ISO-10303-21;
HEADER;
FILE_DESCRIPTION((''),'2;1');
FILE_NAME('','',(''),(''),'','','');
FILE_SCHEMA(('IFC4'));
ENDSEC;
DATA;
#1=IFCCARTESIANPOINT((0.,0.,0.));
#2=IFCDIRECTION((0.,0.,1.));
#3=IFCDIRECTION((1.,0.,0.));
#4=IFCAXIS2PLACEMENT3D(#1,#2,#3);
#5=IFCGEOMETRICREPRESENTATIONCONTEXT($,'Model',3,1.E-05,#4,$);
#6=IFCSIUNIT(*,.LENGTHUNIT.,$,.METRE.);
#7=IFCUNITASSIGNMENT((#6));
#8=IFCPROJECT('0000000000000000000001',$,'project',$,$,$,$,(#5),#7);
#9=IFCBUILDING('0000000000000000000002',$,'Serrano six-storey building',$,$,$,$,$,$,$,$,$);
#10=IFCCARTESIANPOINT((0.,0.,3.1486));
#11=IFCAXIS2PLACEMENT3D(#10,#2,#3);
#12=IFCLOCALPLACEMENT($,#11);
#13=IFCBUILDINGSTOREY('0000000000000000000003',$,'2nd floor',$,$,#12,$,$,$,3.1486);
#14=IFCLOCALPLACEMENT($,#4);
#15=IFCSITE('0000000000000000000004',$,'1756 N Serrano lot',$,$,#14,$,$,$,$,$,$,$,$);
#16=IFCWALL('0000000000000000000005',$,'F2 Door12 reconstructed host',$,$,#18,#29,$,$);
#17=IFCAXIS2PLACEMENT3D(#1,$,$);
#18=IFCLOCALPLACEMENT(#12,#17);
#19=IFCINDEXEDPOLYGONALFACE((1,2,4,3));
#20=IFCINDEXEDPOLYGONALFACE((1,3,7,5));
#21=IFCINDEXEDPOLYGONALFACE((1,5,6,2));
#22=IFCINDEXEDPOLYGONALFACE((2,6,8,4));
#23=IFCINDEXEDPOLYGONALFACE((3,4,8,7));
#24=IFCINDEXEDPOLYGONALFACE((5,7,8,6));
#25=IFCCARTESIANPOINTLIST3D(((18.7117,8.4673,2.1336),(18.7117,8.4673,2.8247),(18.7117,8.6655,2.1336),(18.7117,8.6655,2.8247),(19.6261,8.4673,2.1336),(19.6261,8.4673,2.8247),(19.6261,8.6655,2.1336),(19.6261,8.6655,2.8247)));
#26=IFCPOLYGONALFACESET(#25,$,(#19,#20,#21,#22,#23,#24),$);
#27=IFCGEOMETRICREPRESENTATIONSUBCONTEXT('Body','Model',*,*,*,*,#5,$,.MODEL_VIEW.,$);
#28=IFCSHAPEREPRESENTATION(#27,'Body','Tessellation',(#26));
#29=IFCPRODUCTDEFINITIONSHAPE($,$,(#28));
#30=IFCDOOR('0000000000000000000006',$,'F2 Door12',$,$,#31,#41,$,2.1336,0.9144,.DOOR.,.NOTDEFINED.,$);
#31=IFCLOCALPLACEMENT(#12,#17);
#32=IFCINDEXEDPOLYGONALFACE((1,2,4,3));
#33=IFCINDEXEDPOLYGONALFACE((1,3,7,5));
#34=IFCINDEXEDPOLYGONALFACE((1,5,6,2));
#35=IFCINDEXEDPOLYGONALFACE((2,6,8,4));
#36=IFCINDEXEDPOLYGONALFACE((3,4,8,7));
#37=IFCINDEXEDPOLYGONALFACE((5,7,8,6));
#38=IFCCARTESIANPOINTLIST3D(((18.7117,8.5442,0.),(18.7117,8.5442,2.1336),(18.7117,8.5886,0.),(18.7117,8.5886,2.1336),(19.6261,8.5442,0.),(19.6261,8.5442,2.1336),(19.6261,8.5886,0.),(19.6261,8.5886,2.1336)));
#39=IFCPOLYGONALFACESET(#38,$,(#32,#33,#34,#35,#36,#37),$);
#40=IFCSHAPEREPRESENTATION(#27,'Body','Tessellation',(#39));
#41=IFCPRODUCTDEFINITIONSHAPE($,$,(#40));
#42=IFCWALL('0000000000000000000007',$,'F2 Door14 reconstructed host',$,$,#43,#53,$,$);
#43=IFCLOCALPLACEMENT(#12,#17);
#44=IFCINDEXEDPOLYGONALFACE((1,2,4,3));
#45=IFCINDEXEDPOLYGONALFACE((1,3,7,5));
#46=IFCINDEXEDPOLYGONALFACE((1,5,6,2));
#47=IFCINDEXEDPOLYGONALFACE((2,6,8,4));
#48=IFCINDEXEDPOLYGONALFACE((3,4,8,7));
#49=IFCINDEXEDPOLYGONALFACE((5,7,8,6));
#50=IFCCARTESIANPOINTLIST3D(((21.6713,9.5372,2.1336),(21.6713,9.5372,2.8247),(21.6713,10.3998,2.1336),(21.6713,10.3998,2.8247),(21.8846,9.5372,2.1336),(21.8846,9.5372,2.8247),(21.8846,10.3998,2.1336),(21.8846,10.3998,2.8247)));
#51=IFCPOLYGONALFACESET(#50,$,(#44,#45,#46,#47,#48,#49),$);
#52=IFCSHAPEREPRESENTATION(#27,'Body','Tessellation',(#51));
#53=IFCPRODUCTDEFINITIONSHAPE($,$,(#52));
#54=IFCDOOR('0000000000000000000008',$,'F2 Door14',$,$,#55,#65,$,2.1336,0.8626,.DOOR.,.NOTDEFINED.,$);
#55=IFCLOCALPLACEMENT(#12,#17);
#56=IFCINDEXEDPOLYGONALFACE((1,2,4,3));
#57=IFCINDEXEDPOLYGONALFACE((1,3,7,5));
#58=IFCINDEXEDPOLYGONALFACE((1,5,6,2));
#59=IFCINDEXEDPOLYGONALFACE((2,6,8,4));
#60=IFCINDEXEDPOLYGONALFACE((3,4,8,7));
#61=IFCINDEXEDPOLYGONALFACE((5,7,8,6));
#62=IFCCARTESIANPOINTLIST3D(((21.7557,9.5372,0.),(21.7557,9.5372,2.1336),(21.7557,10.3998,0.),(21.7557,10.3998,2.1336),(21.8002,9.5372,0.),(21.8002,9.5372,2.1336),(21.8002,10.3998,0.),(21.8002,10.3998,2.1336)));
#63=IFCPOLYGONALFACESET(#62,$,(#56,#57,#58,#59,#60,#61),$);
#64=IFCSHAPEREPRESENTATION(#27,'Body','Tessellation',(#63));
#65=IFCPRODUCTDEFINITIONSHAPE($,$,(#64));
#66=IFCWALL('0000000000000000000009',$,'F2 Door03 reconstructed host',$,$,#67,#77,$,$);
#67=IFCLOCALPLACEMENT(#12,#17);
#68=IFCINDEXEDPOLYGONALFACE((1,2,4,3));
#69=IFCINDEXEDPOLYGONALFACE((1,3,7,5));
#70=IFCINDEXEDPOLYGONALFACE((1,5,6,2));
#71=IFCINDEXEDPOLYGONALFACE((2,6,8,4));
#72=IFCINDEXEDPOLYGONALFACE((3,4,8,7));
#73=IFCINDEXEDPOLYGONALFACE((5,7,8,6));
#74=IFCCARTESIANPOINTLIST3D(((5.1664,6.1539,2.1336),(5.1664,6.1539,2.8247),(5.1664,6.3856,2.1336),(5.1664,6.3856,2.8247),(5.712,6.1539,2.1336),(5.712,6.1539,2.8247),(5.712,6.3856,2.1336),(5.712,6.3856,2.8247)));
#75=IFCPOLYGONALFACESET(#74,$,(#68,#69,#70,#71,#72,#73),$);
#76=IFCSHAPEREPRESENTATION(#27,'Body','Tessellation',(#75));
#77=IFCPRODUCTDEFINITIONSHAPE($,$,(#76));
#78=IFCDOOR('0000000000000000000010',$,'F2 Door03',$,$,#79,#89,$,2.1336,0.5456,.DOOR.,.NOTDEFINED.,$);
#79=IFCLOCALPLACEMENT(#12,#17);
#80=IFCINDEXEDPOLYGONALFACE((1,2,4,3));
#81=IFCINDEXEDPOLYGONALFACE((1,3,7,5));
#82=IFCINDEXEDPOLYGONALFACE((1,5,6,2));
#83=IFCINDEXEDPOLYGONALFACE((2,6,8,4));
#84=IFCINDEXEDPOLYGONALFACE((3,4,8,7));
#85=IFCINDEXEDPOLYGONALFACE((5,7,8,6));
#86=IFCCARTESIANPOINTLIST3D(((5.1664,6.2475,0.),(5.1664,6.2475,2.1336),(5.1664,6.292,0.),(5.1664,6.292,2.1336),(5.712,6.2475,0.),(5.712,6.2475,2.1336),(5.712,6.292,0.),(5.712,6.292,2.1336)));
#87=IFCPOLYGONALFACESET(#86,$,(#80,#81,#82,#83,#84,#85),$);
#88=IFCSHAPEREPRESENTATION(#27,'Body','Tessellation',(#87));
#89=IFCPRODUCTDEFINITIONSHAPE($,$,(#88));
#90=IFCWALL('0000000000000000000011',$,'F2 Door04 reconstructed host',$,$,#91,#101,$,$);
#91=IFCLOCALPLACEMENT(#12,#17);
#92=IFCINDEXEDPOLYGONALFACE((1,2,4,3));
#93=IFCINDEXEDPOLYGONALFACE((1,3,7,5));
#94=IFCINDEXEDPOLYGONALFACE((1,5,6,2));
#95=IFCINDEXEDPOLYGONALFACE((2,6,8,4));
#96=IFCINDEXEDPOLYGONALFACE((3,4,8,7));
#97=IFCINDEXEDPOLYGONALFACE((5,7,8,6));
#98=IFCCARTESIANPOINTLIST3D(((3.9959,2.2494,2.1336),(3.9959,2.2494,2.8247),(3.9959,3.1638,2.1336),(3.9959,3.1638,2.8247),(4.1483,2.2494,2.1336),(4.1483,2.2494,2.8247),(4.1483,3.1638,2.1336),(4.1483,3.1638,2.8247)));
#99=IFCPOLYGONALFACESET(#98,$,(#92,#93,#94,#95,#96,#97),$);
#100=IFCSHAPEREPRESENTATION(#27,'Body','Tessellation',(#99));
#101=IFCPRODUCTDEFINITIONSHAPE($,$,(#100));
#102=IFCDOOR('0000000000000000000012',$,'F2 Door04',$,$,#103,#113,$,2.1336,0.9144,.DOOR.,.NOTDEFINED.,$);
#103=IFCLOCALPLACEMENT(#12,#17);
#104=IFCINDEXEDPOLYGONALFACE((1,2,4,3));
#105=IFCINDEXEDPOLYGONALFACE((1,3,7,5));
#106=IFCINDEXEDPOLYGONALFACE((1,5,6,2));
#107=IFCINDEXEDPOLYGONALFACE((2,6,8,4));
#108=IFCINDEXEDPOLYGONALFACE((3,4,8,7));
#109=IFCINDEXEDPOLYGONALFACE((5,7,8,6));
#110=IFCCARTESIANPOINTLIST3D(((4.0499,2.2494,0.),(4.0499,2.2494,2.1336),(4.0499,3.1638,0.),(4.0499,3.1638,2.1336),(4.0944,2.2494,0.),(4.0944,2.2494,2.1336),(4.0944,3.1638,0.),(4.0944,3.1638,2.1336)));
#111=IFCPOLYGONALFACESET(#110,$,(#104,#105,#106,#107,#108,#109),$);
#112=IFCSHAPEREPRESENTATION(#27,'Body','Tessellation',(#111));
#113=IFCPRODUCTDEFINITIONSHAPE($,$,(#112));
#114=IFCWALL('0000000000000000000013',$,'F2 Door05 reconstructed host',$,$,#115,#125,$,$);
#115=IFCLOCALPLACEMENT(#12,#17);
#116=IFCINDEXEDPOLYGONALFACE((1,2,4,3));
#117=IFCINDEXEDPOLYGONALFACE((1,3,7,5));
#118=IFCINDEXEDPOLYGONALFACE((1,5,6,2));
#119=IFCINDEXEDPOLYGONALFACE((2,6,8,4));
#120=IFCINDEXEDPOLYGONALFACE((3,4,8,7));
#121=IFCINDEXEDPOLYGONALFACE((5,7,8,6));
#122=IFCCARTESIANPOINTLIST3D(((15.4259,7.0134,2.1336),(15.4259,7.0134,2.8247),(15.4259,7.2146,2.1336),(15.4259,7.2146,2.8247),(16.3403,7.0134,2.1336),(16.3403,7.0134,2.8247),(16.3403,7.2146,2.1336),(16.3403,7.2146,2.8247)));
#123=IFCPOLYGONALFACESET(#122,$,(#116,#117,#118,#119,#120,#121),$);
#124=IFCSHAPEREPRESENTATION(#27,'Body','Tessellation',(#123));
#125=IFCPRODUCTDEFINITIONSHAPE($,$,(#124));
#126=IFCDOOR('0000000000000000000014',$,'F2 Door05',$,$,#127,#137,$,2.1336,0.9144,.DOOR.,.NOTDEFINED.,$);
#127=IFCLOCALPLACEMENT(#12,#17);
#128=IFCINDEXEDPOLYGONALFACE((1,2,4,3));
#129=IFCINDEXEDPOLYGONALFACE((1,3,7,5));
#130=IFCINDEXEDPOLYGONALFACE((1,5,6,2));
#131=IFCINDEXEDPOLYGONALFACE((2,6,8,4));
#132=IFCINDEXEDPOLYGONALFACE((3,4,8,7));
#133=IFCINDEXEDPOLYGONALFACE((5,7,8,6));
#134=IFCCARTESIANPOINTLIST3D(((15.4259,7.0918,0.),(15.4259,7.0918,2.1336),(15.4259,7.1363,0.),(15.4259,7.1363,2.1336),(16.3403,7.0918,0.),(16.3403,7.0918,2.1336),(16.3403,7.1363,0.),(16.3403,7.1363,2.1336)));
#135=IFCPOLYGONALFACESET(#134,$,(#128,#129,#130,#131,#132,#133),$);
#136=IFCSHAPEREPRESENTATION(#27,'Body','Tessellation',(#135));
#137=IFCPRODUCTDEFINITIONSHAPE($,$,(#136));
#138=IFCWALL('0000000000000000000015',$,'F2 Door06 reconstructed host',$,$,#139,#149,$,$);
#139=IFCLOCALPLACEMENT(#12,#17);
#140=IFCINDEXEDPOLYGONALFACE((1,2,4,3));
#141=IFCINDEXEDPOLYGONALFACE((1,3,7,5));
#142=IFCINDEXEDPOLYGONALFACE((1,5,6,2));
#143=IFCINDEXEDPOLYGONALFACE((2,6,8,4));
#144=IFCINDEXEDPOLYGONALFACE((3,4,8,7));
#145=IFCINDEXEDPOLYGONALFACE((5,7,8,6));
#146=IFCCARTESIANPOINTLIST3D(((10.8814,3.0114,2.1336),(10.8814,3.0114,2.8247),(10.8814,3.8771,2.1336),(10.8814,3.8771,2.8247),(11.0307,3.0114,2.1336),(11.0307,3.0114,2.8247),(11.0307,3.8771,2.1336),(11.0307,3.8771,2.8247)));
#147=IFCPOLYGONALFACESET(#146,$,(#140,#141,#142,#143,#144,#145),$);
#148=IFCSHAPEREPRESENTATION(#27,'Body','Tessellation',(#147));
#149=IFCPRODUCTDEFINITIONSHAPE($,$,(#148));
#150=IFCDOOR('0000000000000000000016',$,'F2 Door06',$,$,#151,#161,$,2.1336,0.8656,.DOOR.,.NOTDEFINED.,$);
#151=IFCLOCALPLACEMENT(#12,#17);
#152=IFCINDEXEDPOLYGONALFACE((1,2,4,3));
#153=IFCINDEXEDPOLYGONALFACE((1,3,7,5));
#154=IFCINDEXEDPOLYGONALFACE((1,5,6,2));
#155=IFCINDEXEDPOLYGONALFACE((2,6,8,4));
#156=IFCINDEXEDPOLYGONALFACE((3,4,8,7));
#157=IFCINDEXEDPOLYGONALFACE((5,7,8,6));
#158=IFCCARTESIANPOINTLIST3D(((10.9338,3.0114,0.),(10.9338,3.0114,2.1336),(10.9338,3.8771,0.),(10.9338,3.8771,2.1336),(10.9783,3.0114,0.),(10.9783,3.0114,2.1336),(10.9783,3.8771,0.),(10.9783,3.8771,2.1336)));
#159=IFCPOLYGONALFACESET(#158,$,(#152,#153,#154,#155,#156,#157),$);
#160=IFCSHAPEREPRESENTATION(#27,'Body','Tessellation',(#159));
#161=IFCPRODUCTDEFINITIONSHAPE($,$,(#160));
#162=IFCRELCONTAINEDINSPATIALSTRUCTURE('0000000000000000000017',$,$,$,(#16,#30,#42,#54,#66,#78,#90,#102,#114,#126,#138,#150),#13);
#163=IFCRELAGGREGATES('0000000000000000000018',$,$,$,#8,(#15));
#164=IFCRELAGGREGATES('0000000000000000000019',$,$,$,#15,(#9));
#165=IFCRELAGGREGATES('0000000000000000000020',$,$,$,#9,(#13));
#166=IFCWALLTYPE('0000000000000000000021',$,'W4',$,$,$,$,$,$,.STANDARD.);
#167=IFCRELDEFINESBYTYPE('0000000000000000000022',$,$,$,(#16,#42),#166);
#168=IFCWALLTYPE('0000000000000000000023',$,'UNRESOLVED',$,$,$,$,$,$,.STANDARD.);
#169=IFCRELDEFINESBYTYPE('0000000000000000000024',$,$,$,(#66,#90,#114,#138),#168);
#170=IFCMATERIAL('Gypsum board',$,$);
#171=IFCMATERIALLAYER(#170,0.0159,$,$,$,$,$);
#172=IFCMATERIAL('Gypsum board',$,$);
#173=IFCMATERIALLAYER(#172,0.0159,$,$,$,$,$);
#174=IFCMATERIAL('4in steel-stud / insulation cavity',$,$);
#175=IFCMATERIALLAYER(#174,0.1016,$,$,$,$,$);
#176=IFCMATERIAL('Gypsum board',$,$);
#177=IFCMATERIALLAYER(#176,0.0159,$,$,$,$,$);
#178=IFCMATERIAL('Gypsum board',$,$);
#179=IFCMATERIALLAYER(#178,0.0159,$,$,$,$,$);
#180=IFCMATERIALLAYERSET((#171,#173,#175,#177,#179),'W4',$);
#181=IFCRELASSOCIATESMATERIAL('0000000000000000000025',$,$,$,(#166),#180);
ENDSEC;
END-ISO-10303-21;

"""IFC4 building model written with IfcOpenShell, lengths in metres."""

from ifc_helpers import new_model, si_unit, frame, origin_with_axes, place, context, subcontext, project, spatial, polyline, outline, extrude, material, layer, layer_set, type_object, element, fill, save


model = new_model("IFC4")

# Units and contexts
model_context = context("Model", 3, precision=1e-05, world=origin_with_axes())
body_context = subcontext(model_context, "Body", "Model", "MODEL_VIEW")
ifc_project = project(units=[si_unit("LENGTHUNIT", "METRE")], contexts=[model_context])

# Site, building, storey
site_placement = place(None, origin_with_axes())
site = spatial("IfcSite", under=ifc_project, at=site_placement, Name="1756 N Serrano lot")
building = spatial("IfcBuilding", under=site, Name="Serrano six-storey building")
storey_placement = place(None, frame((0.0, 0.0, 3.1486), z_axis=(0.0, 0.0, 1.0), x_axis=(1.0, 0.0, 0.0)))
storey = spatial("IfcBuildingStorey", under=building, at=storey_placement, Name="2nd floor", Elevation=3.1486)

# Walls, openings, doors
ifc_material_1 = material(Name="Gypsum board")
ifc_layer_1 = layer(ifc_material_1, 0.0159)
ifc_material_2 = material(Name="Gypsum board")
ifc_layer_2 = layer(ifc_material_2, 0.0159)
ifc_material_3 = material(Name="4in steel-stud / insulation cavity")
ifc_layer_3 = layer(ifc_material_3, 0.1016)
ifc_material_4 = material(Name="Gypsum board")
ifc_layer_4 = layer(ifc_material_4, 0.0159)
ifc_material_5 = material(Name="Gypsum board")
ifc_layer_5 = layer(ifc_material_5, 0.0159)
ifc_layer_set = layer_set([ifc_layer_1, ifc_layer_2, ifc_layer_3, ifc_layer_4, ifc_layer_5], Name="W4")
wall_type_1 = type_object("IfcWallType", Name="W4", PredefinedType="STANDARD", material=ifc_layer_set)
wall_1_placement = place(storey_placement, frame((0.0, 0.0, -3.1486), z_axis=(0.0, 0.0, 1.0), x_axis=(1.0, 0.0, 0.0)))
wall_1 = element("IfcWall", 1, at=wall_1_placement, inside=storey, type_object=wall_type_1, Name="F2 Door12 reconstructed host", context=body_context, shape_type="SweptSolid", body=[
    extrude(outline(polyline([(18.7117, 8.4673), (18.7117, 8.6655), (19.6261, 8.6655), (19.6261, 8.4673), (18.7117, 8.4673)])), frame((0.0, 0.0, 3.1486)), (0.0, 0.0, 1.0), 2.8247),
])
opening_1_placement = place(None, origin_with_axes())
opening_1 = element("IfcOpeningElement", 2, at=opening_1_placement, cuts=wall_1, PredefinedType="OPENING", context=body_context, shape_type="SweptSolid", body=[
    extrude(outline(polyline([(18.7117, 8.4491), (18.7117, 8.6838), (19.6261, 8.6838), (19.6261, 8.4491), (18.7117, 8.4491)])), frame((0.0, 0.0, 3.1486)), (0.0, 0.0, 1.0), 2.1336),
])
door_1_placement = place(storey_placement, frame((0.0, 0.0, -3.1486), z_axis=(0.0, 0.0, 1.0), x_axis=(1.0, 0.0, 0.0)))
door_1 = element("IfcDoor", 3, at=door_1_placement, inside=storey, Name="F2 Door12", OperationType="NOTDEFINED", OverallHeight=2.1336, OverallWidth=0.9144, PredefinedType="DOOR", context=body_context, shape_type="SweptSolid", body=[
    extrude(outline(polyline([(18.7117, 8.5442), (18.7117, 8.5886), (19.6261, 8.5886), (19.6261, 8.5442), (18.7117, 8.5442)])), frame((0.0, 0.0, 3.1486)), (0.0, 0.0, 1.0), 2.1336),
])
fill(opening_1, door_1)
wall_2_placement = place(storey_placement, frame((0.0, 0.0, -3.1486), z_axis=(0.0, 0.0, 1.0), x_axis=(1.0, 0.0, 0.0)))
wall_2 = element("IfcWall", 4, at=wall_2_placement, inside=storey, type_object=wall_type_1, Name="F2 Door14 reconstructed host", context=body_context, shape_type="SweptSolid", body=[
    extrude(outline(polyline([(21.6713, 10.3998), (21.8846, 10.3998), (21.8846, 9.5372), (21.6713, 9.5372), (21.6713, 10.3998)])), frame((0.0, 0.0, 3.1486)), (0.0, 0.0, 1.0), 2.8247),
])
opening_2_placement = place(None, origin_with_axes())
opening_2 = element("IfcOpeningElement", 5, at=opening_2_placement, cuts=wall_2, PredefinedType="OPENING", context=body_context, shape_type="SweptSolid", body=[
    extrude(outline(polyline([(21.653, 10.3998), (21.9029, 10.3998), (21.9029, 9.5372), (21.653, 9.5372), (21.653, 10.3998)])), frame((0.0, 0.0, 3.1486)), (0.0, 0.0, 1.0), 2.1336),
])
door_2_placement = place(storey_placement, frame((0.0, 0.0, -3.1486), z_axis=(0.0, 0.0, 1.0), x_axis=(1.0, 0.0, 0.0)))
door_2 = element("IfcDoor", 6, at=door_2_placement, inside=storey, Name="F2 Door14", OperationType="NOTDEFINED", OverallHeight=2.1336, OverallWidth=0.8626, PredefinedType="DOOR", context=body_context, shape_type="SweptSolid", body=[
    extrude(outline(polyline([(21.7557, 10.3998), (21.8002, 10.3998), (21.8002, 9.5372), (21.7557, 9.5372), (21.7557, 10.3998)])), frame((0.0, 0.0, 3.1486)), (0.0, 0.0, 1.0), 2.1336),
])
fill(opening_2, door_2)
wall_type_2 = type_object("IfcWallType", Name="UNRESOLVED", PredefinedType="STANDARD")
wall_3_placement = place(storey_placement, frame((0.0, 0.0, -3.1486), z_axis=(0.0, 0.0, 1.0), x_axis=(1.0, 0.0, 0.0)))
wall_3 = element("IfcWall", 7, at=wall_3_placement, inside=storey, type_object=wall_type_2, Name="F2 Door03 reconstructed host", context=body_context, shape_type="SweptSolid", body=[
    extrude(outline(polyline([(5.1664, 6.1539), (5.1664, 6.3856), (5.712, 6.3856), (5.712, 6.1539), (5.1664, 6.1539)])), frame((0.0, 0.0, 3.1486)), (0.0, 0.0, 1.0), 2.8247),
])
opening_3_placement = place(None, origin_with_axes())
opening_3 = element("IfcOpeningElement", 8, at=opening_3_placement, cuts=wall_3, PredefinedType="OPENING", context=body_context, shape_type="SweptSolid", body=[
    extrude(outline(polyline([(5.1664, 6.1356), (5.1664, 6.4038), (5.712, 6.4038), (5.712, 6.1356), (5.1664, 6.1356)])), frame((0.0, 0.0, 3.1486)), (0.0, 0.0, 1.0), 2.1336),
])
door_3_placement = place(storey_placement, frame((0.0, 0.0, -3.1486), z_axis=(0.0, 0.0, 1.0), x_axis=(1.0, 0.0, 0.0)))
door_3 = element("IfcDoor", 9, at=door_3_placement, inside=storey, Name="F2 Door03", OperationType="NOTDEFINED", OverallHeight=2.1336, OverallWidth=0.5456, PredefinedType="DOOR", context=body_context, shape_type="SweptSolid", body=[
    extrude(outline(polyline([(5.1664, 6.2475), (5.1664, 6.292), (5.712, 6.292), (5.712, 6.2475), (5.1664, 6.2475)])), frame((0.0, 0.0, 3.1486)), (0.0, 0.0, 1.0), 2.1336),
])
fill(opening_3, door_3)
wall_4_placement = place(storey_placement, frame((0.0, 0.0, -3.1486), z_axis=(0.0, 0.0, 1.0), x_axis=(1.0, 0.0, 0.0)))
wall_4 = element("IfcWall", 10, at=wall_4_placement, inside=storey, type_object=wall_type_2, Name="F2 Door04 reconstructed host", context=body_context, shape_type="SweptSolid", body=[
    extrude(outline(polyline([(3.9959, 3.1638), (4.1483, 3.1638), (4.1483, 2.2494), (3.9959, 2.2494), (3.9959, 3.1638)])), frame((0.0, 0.0, 3.1486)), (0.0, 0.0, 1.0), 2.8247),
])
opening_4_placement = place(None, origin_with_axes())
opening_4 = element("IfcOpeningElement", 11, at=opening_4_placement, cuts=wall_4, PredefinedType="OPENING", context=body_context, shape_type="SweptSolid", body=[
    extrude(outline(polyline([(3.9776, 3.1638), (4.1666, 3.1638), (4.1666, 2.2494), (3.9776, 2.2494), (3.9776, 3.1638)])), frame((0.0, 0.0, 3.1486)), (0.0, 0.0, 1.0), 2.1336),
])
door_4_placement = place(storey_placement, frame((0.0, 0.0, -3.1486), z_axis=(0.0, 0.0, 1.0), x_axis=(1.0, 0.0, 0.0)))
door_4 = element("IfcDoor", 12, at=door_4_placement, inside=storey, Name="F2 Door04", OperationType="NOTDEFINED", OverallHeight=2.1336, OverallWidth=0.9144, PredefinedType="DOOR", context=body_context, shape_type="SweptSolid", body=[
    extrude(outline(polyline([(4.0499, 3.1638), (4.0944, 3.1638), (4.0944, 2.2494), (4.0499, 2.2494), (4.0499, 3.1638)])), frame((0.0, 0.0, 3.1486)), (0.0, 0.0, 1.0), 2.1336),
])
fill(opening_4, door_4)
wall_5_placement = place(storey_placement, frame((0.0, 0.0, -3.1486), z_axis=(0.0, 0.0, 1.0), x_axis=(1.0, 0.0, 0.0)))
wall_5 = element("IfcWall", 13, at=wall_5_placement, inside=storey, type_object=wall_type_2, Name="F2 Door05 reconstructed host", context=body_context, shape_type="SweptSolid", body=[
    extrude(outline(polyline([(15.4259, 7.0134), (15.4259, 7.2146), (16.3403, 7.2146), (16.3403, 7.0134), (15.4259, 7.0134)])), frame((0.0, 0.0, 3.1486)), (0.0, 0.0, 1.0), 2.8247),
])
opening_5_placement = place(None, origin_with_axes())
opening_5 = element("IfcOpeningElement", 14, at=opening_5_placement, cuts=wall_5, PredefinedType="OPENING", context=body_context, shape_type="SweptSolid", body=[
    extrude(outline(polyline([(15.4259, 6.9952), (15.4259, 7.2329), (16.3403, 7.2329), (16.3403, 6.9952), (15.4259, 6.9952)])), frame((0.0, 0.0, 3.1486)), (0.0, 0.0, 1.0), 2.1336),
])
door_5_placement = place(storey_placement, frame((0.0, 0.0, -3.1486), z_axis=(0.0, 0.0, 1.0), x_axis=(1.0, 0.0, 0.0)))
door_5 = element("IfcDoor", 15, at=door_5_placement, inside=storey, Name="F2 Door05", OperationType="NOTDEFINED", OverallHeight=2.1336, OverallWidth=0.9144, PredefinedType="DOOR", context=body_context, shape_type="SweptSolid", body=[
    extrude(outline(polyline([(15.4259, 7.0918), (15.4259, 7.1363), (16.3403, 7.1363), (16.3403, 7.0918), (15.4259, 7.0918)])), frame((0.0, 0.0, 3.1486)), (0.0, 0.0, 1.0), 2.1336),
])
fill(opening_5, door_5)
wall_6_placement = place(storey_placement, frame((0.0, 0.0, -3.1486), z_axis=(0.0, 0.0, 1.0), x_axis=(1.0, 0.0, 0.0)))
wall_6 = element("IfcWall", 16, at=wall_6_placement, inside=storey, type_object=wall_type_2, Name="F2 Door06 reconstructed host", context=body_context, shape_type="SweptSolid", body=[
    extrude(outline(polyline([(10.8814, 3.8771), (11.0307, 3.8771), (11.0307, 3.0114), (10.8814, 3.0114), (10.8814, 3.8771)])), frame((0.0, 0.0, 3.1486)), (0.0, 0.0, 1.0), 2.8247),
])
opening_6_placement = place(None, origin_with_axes())
opening_6 = element("IfcOpeningElement", 17, at=opening_6_placement, cuts=wall_6, PredefinedType="OPENING", context=body_context, shape_type="SweptSolid", body=[
    extrude(outline(polyline([(10.8631, 3.8771), (11.049, 3.8771), (11.049, 3.0114), (10.8631, 3.0114), (10.8631, 3.8771)])), frame((0.0, 0.0, 3.1486)), (0.0, 0.0, 1.0), 2.1336),
])
door_6_placement = place(storey_placement, frame((0.0, 0.0, -3.1486), z_axis=(0.0, 0.0, 1.0), x_axis=(1.0, 0.0, 0.0)))
door_6 = element("IfcDoor", 18, at=door_6_placement, inside=storey, Name="F2 Door06", OperationType="NOTDEFINED", OverallHeight=2.1336, OverallWidth=0.8656, PredefinedType="DOOR", context=body_context, shape_type="SweptSolid", body=[
    extrude(outline(polyline([(10.9338, 3.8771), (10.9783, 3.8771), (10.9783, 3.0114), (10.9338, 3.0114), (10.9338, 3.8771)])), frame((0.0, 0.0, 3.1486)), (0.0, 0.0, 1.0), 2.1336),
])
fill(opening_6, door_6)

save(model, "model.ifc")
